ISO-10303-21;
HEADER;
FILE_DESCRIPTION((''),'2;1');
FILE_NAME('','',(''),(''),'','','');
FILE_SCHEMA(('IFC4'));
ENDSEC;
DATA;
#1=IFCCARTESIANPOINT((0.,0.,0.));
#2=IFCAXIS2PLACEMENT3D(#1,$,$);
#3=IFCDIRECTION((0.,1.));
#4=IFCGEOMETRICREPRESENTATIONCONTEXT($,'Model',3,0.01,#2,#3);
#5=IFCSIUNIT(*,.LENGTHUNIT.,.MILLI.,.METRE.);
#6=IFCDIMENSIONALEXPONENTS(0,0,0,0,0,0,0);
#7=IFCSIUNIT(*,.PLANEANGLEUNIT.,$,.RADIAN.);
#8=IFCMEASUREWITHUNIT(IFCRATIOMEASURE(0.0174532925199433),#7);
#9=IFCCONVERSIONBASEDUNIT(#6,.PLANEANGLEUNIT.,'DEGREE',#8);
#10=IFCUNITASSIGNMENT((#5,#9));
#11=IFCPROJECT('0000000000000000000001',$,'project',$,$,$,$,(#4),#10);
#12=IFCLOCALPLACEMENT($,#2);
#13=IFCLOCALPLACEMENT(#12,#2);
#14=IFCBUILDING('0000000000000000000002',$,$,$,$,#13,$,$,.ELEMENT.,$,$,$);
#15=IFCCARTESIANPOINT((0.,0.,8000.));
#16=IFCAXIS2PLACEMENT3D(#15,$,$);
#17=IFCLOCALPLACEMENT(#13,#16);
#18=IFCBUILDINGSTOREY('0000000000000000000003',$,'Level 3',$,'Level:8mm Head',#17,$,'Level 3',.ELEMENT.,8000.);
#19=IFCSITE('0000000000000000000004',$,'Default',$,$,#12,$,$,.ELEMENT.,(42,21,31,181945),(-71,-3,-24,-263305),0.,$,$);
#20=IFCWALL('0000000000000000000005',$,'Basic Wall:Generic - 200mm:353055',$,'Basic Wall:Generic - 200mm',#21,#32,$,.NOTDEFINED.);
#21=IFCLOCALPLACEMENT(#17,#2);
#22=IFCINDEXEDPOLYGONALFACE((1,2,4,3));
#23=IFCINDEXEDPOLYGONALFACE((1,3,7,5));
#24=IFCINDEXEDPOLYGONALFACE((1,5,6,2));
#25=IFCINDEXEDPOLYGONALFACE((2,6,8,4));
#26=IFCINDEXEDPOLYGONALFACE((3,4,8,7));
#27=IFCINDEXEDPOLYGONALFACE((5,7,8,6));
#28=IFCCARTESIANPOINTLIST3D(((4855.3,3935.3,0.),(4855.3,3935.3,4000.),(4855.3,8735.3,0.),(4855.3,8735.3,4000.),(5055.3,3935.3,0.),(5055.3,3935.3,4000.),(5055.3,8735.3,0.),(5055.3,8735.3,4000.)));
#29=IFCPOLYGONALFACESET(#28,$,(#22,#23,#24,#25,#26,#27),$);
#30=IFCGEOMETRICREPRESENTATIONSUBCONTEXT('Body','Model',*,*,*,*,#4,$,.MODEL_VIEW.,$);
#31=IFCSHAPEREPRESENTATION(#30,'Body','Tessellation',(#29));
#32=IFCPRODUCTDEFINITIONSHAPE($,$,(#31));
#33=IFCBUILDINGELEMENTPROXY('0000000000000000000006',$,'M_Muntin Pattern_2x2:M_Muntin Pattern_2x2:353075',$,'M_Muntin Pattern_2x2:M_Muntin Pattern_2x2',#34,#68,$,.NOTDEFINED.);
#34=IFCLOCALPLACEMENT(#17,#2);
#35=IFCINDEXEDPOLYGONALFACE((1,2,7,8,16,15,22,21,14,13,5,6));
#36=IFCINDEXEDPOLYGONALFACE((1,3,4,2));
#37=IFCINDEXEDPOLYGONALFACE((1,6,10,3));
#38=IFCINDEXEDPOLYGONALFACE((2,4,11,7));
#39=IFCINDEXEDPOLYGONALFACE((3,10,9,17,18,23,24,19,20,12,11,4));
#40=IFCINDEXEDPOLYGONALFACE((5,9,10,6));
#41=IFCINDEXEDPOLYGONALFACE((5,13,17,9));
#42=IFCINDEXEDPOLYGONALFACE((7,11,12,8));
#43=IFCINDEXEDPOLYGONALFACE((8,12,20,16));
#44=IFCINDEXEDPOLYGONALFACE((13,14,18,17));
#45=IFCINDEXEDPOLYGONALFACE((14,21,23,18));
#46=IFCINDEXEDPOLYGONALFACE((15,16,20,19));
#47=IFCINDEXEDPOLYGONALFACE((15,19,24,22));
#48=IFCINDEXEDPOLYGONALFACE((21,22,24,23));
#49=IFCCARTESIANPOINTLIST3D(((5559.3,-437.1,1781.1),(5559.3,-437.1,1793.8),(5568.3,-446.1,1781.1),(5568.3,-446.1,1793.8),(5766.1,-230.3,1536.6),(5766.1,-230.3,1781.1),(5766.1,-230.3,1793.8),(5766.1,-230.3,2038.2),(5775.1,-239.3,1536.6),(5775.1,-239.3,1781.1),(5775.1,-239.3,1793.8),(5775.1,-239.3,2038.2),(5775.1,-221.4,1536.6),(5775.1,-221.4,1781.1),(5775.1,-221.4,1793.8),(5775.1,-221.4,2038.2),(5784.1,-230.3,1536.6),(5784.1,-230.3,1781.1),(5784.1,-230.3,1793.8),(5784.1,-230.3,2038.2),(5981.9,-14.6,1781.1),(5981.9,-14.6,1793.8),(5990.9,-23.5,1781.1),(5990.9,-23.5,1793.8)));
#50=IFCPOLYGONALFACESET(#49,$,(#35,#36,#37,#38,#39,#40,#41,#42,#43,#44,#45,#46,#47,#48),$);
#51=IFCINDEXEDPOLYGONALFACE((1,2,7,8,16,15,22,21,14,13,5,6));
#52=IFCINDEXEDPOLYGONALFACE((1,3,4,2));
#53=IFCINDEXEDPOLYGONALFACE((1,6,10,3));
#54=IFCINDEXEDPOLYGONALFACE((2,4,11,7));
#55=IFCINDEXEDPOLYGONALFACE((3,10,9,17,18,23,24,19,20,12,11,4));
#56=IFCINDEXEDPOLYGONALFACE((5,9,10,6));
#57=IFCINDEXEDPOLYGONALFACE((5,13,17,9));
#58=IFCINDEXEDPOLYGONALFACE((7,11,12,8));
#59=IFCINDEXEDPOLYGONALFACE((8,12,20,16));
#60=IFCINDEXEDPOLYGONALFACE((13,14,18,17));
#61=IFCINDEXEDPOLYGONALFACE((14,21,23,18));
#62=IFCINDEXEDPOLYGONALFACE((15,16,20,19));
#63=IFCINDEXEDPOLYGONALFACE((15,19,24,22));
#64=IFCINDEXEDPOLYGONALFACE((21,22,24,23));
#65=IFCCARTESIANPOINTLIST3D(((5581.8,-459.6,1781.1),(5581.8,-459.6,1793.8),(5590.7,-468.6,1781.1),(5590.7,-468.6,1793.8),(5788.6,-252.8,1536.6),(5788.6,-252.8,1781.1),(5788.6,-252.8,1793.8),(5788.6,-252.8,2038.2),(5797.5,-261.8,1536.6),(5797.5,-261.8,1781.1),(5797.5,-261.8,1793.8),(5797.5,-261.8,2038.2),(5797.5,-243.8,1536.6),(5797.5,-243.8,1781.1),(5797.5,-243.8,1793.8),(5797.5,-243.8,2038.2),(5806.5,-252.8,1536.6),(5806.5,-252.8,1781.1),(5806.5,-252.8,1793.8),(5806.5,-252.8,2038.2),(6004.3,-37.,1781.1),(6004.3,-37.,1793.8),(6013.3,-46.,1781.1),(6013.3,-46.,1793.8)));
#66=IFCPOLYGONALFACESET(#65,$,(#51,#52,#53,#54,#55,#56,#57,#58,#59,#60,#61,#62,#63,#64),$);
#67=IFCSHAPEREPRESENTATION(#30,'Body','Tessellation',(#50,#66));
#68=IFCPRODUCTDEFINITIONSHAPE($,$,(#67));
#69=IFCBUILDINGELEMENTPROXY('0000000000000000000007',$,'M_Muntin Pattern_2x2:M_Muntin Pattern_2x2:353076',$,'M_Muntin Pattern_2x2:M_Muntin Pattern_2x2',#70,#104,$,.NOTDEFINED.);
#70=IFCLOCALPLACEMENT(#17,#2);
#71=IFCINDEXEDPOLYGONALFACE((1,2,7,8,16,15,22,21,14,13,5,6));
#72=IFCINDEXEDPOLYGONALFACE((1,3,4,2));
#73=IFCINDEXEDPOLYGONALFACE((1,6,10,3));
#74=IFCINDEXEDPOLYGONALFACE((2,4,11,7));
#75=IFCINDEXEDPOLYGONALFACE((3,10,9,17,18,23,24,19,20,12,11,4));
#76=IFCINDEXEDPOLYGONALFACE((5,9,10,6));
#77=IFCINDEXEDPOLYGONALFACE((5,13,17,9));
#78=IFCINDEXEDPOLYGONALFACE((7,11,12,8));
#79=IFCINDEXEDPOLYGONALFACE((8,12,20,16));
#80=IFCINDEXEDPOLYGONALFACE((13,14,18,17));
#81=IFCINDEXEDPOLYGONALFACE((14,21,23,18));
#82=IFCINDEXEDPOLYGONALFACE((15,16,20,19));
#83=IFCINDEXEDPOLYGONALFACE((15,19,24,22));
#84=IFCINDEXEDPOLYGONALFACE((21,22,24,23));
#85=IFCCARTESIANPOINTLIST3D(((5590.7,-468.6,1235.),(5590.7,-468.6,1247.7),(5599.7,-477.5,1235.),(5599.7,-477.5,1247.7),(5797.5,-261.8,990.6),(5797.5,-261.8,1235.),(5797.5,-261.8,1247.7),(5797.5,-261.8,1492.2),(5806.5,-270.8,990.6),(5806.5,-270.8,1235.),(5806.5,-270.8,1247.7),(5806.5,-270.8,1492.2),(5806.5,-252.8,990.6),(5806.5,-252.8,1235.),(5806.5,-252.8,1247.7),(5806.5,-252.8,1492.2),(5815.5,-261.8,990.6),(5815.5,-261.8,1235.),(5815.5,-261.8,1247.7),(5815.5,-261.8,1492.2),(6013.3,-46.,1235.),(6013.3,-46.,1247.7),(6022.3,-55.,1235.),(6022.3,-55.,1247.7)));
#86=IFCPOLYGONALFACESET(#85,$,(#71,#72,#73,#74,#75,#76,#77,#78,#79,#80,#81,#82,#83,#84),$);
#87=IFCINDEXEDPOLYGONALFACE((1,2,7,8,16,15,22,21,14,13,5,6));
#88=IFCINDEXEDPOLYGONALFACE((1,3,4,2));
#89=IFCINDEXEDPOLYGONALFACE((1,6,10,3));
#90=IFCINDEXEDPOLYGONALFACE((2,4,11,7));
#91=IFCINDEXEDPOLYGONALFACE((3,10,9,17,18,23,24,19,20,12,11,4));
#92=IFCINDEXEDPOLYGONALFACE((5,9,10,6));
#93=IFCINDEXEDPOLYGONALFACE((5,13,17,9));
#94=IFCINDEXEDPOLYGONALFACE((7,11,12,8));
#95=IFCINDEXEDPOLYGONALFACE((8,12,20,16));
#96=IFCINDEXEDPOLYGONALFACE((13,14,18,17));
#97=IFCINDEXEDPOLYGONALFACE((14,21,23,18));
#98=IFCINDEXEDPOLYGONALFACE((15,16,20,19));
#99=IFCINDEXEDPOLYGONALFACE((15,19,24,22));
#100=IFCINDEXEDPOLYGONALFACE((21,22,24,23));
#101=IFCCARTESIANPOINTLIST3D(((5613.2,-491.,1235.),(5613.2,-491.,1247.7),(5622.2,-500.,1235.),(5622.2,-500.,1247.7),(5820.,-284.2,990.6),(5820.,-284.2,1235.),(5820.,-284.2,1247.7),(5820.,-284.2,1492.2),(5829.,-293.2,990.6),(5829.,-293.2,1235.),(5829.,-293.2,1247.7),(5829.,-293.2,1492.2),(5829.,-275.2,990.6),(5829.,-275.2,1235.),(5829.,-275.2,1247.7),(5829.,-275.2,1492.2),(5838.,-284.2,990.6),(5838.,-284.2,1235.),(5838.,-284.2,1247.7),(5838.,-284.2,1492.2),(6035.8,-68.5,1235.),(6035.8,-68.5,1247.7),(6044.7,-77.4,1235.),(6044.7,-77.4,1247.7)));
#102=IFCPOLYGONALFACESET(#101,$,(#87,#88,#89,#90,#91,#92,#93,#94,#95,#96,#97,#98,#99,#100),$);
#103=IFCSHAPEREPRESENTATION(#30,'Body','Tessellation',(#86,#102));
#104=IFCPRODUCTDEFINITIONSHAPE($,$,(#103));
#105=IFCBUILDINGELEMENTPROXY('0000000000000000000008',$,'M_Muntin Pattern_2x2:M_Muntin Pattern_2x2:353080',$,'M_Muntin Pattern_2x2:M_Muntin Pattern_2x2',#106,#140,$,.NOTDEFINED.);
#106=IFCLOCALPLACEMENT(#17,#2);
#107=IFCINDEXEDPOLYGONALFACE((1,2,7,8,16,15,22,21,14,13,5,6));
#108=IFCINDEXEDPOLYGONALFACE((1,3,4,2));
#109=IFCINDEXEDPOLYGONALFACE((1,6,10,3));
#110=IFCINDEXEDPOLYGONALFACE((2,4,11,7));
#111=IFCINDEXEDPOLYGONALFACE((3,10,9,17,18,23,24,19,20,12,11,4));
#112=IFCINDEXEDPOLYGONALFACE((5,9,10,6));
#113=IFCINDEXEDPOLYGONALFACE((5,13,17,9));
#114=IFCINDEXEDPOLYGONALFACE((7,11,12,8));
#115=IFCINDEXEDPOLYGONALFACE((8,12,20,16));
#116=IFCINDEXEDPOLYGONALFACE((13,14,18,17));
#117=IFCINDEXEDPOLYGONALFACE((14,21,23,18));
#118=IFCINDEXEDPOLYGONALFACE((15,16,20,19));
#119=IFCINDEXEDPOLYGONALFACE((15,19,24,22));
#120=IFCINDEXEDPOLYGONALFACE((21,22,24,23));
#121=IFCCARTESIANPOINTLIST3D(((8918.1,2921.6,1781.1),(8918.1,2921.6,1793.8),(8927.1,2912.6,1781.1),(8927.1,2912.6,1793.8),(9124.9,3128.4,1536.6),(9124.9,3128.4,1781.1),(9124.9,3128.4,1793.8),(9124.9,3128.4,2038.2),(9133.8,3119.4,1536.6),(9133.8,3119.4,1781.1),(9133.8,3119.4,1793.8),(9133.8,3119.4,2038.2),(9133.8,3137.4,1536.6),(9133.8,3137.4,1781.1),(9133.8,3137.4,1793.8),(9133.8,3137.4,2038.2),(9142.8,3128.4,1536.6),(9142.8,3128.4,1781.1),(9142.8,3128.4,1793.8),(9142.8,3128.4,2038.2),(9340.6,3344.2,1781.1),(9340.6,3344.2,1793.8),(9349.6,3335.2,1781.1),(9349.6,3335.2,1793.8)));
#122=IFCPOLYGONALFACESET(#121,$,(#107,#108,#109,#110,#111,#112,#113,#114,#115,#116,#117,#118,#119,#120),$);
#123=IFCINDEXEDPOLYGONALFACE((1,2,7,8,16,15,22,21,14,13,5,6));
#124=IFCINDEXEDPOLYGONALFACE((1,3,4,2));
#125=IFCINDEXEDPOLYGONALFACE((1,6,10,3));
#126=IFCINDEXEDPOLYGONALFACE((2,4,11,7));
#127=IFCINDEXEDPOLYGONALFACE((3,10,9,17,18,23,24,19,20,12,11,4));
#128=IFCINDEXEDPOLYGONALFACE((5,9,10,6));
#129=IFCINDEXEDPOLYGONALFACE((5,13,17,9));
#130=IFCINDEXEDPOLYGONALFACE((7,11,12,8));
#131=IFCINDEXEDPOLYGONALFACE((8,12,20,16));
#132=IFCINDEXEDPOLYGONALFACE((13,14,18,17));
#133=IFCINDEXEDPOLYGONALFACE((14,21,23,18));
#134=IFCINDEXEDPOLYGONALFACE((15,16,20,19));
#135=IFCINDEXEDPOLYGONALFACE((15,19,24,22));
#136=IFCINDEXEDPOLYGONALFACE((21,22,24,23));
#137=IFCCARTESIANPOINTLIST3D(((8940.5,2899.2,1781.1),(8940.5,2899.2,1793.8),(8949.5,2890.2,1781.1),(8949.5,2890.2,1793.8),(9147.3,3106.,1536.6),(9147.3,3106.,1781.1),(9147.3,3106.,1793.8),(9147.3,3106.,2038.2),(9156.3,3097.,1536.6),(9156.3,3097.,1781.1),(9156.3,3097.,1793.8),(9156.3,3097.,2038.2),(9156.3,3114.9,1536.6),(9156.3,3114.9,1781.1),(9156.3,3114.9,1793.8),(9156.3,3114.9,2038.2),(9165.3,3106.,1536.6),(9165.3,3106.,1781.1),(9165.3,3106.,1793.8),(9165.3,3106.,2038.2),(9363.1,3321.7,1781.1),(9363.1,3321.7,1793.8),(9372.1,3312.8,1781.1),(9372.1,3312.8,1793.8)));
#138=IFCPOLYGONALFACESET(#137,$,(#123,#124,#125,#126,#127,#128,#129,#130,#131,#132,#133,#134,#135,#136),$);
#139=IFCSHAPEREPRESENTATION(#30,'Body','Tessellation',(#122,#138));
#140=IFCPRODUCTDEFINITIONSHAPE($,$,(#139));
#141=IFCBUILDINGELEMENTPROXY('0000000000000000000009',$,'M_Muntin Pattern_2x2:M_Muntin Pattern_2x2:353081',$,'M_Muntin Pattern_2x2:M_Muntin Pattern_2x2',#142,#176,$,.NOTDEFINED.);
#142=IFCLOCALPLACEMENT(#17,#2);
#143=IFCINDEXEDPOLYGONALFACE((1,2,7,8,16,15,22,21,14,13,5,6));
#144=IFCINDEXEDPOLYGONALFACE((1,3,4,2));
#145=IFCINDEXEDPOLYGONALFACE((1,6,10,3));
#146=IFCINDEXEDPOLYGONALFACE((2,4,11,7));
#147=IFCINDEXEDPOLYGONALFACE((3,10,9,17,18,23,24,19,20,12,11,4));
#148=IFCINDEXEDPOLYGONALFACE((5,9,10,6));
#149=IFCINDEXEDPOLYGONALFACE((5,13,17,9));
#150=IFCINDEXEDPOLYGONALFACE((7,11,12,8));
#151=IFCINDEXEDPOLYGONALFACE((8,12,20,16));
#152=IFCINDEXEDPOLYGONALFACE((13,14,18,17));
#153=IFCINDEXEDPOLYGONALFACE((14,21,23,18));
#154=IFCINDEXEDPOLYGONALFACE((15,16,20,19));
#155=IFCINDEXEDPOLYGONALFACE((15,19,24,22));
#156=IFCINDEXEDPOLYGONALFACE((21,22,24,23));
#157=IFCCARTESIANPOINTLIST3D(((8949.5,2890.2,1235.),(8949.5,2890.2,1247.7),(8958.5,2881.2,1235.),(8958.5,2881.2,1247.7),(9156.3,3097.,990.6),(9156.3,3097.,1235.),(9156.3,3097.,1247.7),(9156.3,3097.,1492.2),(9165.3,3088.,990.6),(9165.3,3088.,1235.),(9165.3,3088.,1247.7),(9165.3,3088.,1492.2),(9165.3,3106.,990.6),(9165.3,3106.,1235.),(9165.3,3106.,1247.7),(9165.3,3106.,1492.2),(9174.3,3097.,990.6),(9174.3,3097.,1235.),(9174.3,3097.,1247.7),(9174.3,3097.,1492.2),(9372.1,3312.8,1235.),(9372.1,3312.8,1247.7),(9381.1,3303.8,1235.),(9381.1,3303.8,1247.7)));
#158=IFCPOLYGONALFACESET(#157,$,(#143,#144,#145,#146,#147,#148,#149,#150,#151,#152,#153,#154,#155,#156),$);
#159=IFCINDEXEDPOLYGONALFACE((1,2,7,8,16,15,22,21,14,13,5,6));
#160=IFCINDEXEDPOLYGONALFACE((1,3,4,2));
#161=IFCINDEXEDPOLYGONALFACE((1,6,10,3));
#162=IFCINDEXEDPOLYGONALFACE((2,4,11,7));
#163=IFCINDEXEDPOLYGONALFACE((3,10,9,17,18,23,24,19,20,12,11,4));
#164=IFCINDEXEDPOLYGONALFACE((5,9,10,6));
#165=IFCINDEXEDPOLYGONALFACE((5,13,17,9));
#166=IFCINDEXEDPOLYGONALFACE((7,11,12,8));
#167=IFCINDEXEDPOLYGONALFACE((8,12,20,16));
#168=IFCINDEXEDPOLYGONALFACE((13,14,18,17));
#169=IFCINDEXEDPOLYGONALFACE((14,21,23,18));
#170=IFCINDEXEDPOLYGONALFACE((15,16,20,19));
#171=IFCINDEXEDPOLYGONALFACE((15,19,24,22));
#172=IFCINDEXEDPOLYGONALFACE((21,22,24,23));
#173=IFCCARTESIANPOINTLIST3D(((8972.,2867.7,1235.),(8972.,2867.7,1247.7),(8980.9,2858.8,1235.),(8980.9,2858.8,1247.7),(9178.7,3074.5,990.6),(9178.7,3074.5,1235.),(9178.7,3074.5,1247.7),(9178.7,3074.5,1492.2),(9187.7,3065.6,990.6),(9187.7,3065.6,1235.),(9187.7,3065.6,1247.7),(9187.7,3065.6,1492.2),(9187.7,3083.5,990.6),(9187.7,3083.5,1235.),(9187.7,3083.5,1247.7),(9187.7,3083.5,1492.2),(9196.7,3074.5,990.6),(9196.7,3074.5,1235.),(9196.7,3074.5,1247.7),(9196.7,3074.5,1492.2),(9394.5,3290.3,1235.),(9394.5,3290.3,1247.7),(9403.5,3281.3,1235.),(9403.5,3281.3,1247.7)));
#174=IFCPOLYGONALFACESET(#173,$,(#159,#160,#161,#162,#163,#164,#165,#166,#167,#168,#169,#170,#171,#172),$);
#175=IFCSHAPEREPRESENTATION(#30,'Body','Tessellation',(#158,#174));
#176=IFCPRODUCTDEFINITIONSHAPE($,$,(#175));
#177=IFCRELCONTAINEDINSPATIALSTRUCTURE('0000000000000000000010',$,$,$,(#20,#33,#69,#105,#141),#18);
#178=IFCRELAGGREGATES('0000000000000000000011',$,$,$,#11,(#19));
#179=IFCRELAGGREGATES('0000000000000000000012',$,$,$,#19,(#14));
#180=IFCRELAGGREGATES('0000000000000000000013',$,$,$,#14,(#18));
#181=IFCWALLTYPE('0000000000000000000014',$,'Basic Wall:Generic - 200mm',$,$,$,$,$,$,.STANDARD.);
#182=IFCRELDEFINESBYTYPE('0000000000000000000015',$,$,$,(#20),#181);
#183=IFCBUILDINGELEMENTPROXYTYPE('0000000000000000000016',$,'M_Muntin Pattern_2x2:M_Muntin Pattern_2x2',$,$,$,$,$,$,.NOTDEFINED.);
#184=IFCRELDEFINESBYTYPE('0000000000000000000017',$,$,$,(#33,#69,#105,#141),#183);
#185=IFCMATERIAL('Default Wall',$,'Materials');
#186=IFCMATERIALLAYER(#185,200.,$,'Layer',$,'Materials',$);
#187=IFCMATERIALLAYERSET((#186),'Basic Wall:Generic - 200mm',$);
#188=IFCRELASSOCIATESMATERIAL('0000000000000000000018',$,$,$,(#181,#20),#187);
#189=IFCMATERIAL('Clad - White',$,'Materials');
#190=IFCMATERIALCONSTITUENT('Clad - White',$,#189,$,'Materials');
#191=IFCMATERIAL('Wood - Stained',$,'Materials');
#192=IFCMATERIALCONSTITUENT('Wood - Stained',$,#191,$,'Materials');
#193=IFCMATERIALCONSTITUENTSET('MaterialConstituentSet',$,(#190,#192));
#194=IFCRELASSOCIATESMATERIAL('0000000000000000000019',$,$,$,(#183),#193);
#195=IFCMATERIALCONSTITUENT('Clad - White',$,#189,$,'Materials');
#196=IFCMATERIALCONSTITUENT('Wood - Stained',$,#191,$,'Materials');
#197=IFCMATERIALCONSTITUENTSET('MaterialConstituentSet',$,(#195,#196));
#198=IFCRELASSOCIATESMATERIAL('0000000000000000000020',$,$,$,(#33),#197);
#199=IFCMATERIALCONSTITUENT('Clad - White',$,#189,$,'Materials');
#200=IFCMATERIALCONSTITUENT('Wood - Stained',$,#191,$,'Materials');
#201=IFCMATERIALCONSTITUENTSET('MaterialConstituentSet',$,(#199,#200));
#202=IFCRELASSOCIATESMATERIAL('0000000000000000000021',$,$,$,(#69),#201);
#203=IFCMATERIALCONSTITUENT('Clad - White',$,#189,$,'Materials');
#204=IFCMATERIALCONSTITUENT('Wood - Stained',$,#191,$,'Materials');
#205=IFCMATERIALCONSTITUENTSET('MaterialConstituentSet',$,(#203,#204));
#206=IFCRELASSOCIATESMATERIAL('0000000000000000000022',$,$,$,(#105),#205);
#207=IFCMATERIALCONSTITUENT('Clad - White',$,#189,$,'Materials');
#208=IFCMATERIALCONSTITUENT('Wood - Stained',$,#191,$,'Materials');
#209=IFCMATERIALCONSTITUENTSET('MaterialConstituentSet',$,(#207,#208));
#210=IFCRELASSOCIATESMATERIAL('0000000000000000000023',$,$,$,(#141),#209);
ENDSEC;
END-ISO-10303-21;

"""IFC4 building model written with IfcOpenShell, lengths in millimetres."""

from ifc_helpers import new_model, entity, si_unit, converted_unit, direction, frame, frame_2d, origin, place, context, subcontext, project, spatial, polyline, rectangle, outline, extrude, source, transform, mapped, material, layer, layer_set, layer_usage, constituent, constituent_set, type_object, type_shapes, element, save


model = new_model("IFC4")

# Units and contexts
model_context = context("Model", 3, precision=0.01, world=origin(), true_north=direction((0.0, 1.0)))
body_context = subcontext(model_context, "Body", "Model", "MODEL_VIEW")
ifc_project = project(units=[si_unit("LENGTHUNIT", "METRE", prefix="MILLI"), converted_unit("PLANEANGLEUNIT", "DEGREE", entity("IfcRatioMeasure", 0.0174532925199433), si_unit("PLANEANGLEUNIT", "RADIAN"), dimensions=[0, 0, 0, 0, 0, 0, 0])], contexts=[model_context])

# Site, building, storey
site_placement = place(None, origin())
site = spatial("IfcSite", under=ifc_project, at=site_placement, Name="Default", CompositionType="ELEMENT", RefLatitude=(42, 21, 31, 181945), RefLongitude=(-71, -3, -24, -263305), RefElevation=0.0)
building_placement = place(site_placement, origin())
building = spatial("IfcBuilding", under=site, at=building_placement, CompositionType="ELEMENT")
storey_placement = place(building_placement, frame((0.0, 0.0, 8000.0)))
storey = spatial("IfcBuildingStorey", under=building, at=storey_placement, Name="Level 3", ObjectType="Level:8mm Head", LongName="Level 3", CompositionType="ELEMENT", Elevation=8000.0)

# Shared definitions
ifc_material_1 = material(Name="Default Wall", Category="Materials")
ifc_layer = layer(ifc_material_1, 200.0, Name="Layer", Category="Materials")
ifc_layer_set = layer_set([ifc_layer], Name="Basic Wall:Generic - 200mm")
wall_type = type_object("IfcWallType", Name="Basic Wall:Generic - 200mm", PredefinedType="STANDARD", material=ifc_layer_set)
ifc_material_2 = material(Name="Wood - Stained", Category="Materials")

# Wall
ifc_layer_usage_1 = layer_usage(ifc_layer_set, "AXIS2", "NEGATIVE", 100.0)
wall_1_placement = place(storey_placement, frame((4955.3, 3935.3, 0.0), z_axis=(0.0, 0.0, 1.0), x_axis=(0.0, 1.0, 0.0)))
element("IfcWall", 1, at=wall_1_placement, inside=storey, type_object=wall_type, material=ifc_layer_usage_1, Name="Basic Wall:Generic - 200mm:353055", ObjectType="Basic Wall:Generic - 200mm", PredefinedType="NOTDEFINED", context=body_context, shape_type="SweptSolid", body=[
    extrude(rectangle(XDim=4800.0, YDim=200.0, at=frame_2d((2400.0, 0.0), x_axis=(-1.0, 0.0))), origin(), (0.0, 0.0, 1.0), 4000.0),
])

# Building element proxies
ifc_material_3 = material(Name="Clad - White", Category="Materials")
ifc_constituent_1 = constituent(ifc_material_3, Name="Clad - White", Category="Materials")
ifc_constituent_2 = constituent(ifc_material_2, Name="Wood - Stained", Category="Materials")
ifc_constituent_set_1 = constituent_set(constituents=[ifc_constituent_1, ifc_constituent_2], Name="MaterialConstituentSet")
ifc_constituent_3 = constituent(ifc_material_3, Name="Clad - White", Category="Materials")
ifc_constituent_4 = constituent(ifc_material_2, Name="Wood - Stained", Category="Materials")
ifc_constituent_set_2 = constituent_set(constituents=[ifc_constituent_3, ifc_constituent_4], Name="MaterialConstituentSet")
building_element_proxy_type_1 = type_object("IfcBuildingElementProxyType", Name="M_Muntin Pattern_2x2:M_Muntin Pattern_2x2", PredefinedType="NOTDEFINED", material=ifc_constituent_set_2)
shared_shape_1 = source(origin(), body_context, "Body", "SweptSolid", [
    extrude(outline(polyline([(6.4, -6.4), (250.8, -6.4), (250.8, 6.3), (6.4, 6.3), (6.4, 298.8), (-6.3, 298.8), (-6.3, 6.3), (-250.8, 6.3), (-250.8, -6.4), (-6.3, -6.4), (-6.3, -298.8), (6.4, -298.8), (6.4, -6.4)])), frame((0.0, 9.5, 250.8), z_axis=(0.0, 1.0, 0.0), x_axis=(0.0, 0.0, 1.0)), (0.0, 0.0, 1.0), 12.7),
    extrude(outline(polyline([(6.4, -6.4), (250.8, -6.4), (250.8, 6.3), (6.4, 6.3), (6.4, 298.8), (-6.3, 298.8), (-6.3, 6.3), (-250.8, 6.3), (-250.8, -6.4), (-6.3, -6.4), (-6.3, -298.8), (6.4, -298.8), (6.4, -6.4)])), frame((0.0, -22.2, 250.8), z_axis=(0.0, 1.0, 0.0), x_axis=(0.0, 0.0, 1.0)), (0.0, 0.0, 1.0), 12.7),
])
type_shapes(building_element_proxy_type_1, [shared_shape_1])
proxy_1_placement = place(storey_placement, frame((5786.3, -241.6, 1536.6), z_axis=(0.0, 0.0, 1.0), x_axis=(0.707107, 0.707107, 0.0)))
element("IfcBuildingElementProxy", 2, at=proxy_1_placement, inside=storey, type_object=building_element_proxy_type_1, material=ifc_constituent_set_1, Name="M_Muntin Pattern_2x2:M_Muntin Pattern_2x2:353075", ObjectType="M_Muntin Pattern_2x2:M_Muntin Pattern_2x2", PredefinedType="NOTDEFINED", context=body_context, shape_type="MappedRepresentation", body=[
    mapped(shared_shape_1, transform((0.0, 0.0, 0.0), scale=1.0)),
])
ifc_constituent_5 = constituent(ifc_material_3, Name="Clad - White", Category="Materials")
ifc_constituent_6 = constituent(ifc_material_2, Name="Wood - Stained", Category="Materials")
ifc_constituent_set_3 = constituent_set(constituents=[ifc_constituent_5, ifc_constituent_6], Name="MaterialConstituentSet")
proxy_2_placement = place(storey_placement, frame((5817.7, -273.0, 990.6), z_axis=(0.0, 0.0, 1.0), x_axis=(0.707107, 0.707107, 0.0)))
element("IfcBuildingElementProxy", 3, at=proxy_2_placement, inside=storey, type_object=building_element_proxy_type_1, material=ifc_constituent_set_3, Name="M_Muntin Pattern_2x2:M_Muntin Pattern_2x2:353076", ObjectType="M_Muntin Pattern_2x2:M_Muntin Pattern_2x2", PredefinedType="NOTDEFINED", context=body_context, shape_type="MappedRepresentation", body=[
    mapped(shared_shape_1, transform((0.0, 0.0, 0.0), scale=1.0)),
])
ifc_constituent_7 = constituent(ifc_material_3, Name="Clad - White", Category="Materials")
ifc_constituent_8 = constituent(ifc_material_2, Name="Wood - Stained", Category="Materials")
ifc_constituent_set_4 = constituent_set(constituents=[ifc_constituent_7, ifc_constituent_8], Name="MaterialConstituentSet")
proxy_3_placement = place(storey_placement, frame((9145.1, 3117.2, 1536.6), z_axis=(0.0, 0.0, 1.0), x_axis=(0.707107, 0.707107, 0.0)))
element("IfcBuildingElementProxy", 4, at=proxy_3_placement, inside=storey, type_object=building_element_proxy_type_1, material=ifc_constituent_set_4, Name="M_Muntin Pattern_2x2:M_Muntin Pattern_2x2:353080", ObjectType="M_Muntin Pattern_2x2:M_Muntin Pattern_2x2", PredefinedType="NOTDEFINED", context=body_context, shape_type="MappedRepresentation", body=[
    mapped(shared_shape_1, transform((0.0, 0.0, 0.0), scale=1.0)),
])
ifc_constituent_9 = constituent(ifc_material_3, Name="Clad - White", Category="Materials")
ifc_constituent_10 = constituent(ifc_material_2, Name="Wood - Stained", Category="Materials")
ifc_constituent_set_5 = constituent_set(constituents=[ifc_constituent_9, ifc_constituent_10], Name="MaterialConstituentSet")
proxy_4_placement = place(storey_placement, frame((9176.5, 3085.8, 990.6), z_axis=(0.0, 0.0, 1.0), x_axis=(0.707107, 0.707107, 0.0)))
element("IfcBuildingElementProxy", 5, at=proxy_4_placement, inside=storey, type_object=building_element_proxy_type_1, material=ifc_constituent_set_5, Name="M_Muntin Pattern_2x2:M_Muntin Pattern_2x2:353081", ObjectType="M_Muntin Pattern_2x2:M_Muntin Pattern_2x2", PredefinedType="NOTDEFINED", context=body_context, shape_type="MappedRepresentation", body=[
    mapped(shared_shape_1, transform((0.0, 0.0, 0.0), scale=1.0)),
])

save(model, "model.ifc")
